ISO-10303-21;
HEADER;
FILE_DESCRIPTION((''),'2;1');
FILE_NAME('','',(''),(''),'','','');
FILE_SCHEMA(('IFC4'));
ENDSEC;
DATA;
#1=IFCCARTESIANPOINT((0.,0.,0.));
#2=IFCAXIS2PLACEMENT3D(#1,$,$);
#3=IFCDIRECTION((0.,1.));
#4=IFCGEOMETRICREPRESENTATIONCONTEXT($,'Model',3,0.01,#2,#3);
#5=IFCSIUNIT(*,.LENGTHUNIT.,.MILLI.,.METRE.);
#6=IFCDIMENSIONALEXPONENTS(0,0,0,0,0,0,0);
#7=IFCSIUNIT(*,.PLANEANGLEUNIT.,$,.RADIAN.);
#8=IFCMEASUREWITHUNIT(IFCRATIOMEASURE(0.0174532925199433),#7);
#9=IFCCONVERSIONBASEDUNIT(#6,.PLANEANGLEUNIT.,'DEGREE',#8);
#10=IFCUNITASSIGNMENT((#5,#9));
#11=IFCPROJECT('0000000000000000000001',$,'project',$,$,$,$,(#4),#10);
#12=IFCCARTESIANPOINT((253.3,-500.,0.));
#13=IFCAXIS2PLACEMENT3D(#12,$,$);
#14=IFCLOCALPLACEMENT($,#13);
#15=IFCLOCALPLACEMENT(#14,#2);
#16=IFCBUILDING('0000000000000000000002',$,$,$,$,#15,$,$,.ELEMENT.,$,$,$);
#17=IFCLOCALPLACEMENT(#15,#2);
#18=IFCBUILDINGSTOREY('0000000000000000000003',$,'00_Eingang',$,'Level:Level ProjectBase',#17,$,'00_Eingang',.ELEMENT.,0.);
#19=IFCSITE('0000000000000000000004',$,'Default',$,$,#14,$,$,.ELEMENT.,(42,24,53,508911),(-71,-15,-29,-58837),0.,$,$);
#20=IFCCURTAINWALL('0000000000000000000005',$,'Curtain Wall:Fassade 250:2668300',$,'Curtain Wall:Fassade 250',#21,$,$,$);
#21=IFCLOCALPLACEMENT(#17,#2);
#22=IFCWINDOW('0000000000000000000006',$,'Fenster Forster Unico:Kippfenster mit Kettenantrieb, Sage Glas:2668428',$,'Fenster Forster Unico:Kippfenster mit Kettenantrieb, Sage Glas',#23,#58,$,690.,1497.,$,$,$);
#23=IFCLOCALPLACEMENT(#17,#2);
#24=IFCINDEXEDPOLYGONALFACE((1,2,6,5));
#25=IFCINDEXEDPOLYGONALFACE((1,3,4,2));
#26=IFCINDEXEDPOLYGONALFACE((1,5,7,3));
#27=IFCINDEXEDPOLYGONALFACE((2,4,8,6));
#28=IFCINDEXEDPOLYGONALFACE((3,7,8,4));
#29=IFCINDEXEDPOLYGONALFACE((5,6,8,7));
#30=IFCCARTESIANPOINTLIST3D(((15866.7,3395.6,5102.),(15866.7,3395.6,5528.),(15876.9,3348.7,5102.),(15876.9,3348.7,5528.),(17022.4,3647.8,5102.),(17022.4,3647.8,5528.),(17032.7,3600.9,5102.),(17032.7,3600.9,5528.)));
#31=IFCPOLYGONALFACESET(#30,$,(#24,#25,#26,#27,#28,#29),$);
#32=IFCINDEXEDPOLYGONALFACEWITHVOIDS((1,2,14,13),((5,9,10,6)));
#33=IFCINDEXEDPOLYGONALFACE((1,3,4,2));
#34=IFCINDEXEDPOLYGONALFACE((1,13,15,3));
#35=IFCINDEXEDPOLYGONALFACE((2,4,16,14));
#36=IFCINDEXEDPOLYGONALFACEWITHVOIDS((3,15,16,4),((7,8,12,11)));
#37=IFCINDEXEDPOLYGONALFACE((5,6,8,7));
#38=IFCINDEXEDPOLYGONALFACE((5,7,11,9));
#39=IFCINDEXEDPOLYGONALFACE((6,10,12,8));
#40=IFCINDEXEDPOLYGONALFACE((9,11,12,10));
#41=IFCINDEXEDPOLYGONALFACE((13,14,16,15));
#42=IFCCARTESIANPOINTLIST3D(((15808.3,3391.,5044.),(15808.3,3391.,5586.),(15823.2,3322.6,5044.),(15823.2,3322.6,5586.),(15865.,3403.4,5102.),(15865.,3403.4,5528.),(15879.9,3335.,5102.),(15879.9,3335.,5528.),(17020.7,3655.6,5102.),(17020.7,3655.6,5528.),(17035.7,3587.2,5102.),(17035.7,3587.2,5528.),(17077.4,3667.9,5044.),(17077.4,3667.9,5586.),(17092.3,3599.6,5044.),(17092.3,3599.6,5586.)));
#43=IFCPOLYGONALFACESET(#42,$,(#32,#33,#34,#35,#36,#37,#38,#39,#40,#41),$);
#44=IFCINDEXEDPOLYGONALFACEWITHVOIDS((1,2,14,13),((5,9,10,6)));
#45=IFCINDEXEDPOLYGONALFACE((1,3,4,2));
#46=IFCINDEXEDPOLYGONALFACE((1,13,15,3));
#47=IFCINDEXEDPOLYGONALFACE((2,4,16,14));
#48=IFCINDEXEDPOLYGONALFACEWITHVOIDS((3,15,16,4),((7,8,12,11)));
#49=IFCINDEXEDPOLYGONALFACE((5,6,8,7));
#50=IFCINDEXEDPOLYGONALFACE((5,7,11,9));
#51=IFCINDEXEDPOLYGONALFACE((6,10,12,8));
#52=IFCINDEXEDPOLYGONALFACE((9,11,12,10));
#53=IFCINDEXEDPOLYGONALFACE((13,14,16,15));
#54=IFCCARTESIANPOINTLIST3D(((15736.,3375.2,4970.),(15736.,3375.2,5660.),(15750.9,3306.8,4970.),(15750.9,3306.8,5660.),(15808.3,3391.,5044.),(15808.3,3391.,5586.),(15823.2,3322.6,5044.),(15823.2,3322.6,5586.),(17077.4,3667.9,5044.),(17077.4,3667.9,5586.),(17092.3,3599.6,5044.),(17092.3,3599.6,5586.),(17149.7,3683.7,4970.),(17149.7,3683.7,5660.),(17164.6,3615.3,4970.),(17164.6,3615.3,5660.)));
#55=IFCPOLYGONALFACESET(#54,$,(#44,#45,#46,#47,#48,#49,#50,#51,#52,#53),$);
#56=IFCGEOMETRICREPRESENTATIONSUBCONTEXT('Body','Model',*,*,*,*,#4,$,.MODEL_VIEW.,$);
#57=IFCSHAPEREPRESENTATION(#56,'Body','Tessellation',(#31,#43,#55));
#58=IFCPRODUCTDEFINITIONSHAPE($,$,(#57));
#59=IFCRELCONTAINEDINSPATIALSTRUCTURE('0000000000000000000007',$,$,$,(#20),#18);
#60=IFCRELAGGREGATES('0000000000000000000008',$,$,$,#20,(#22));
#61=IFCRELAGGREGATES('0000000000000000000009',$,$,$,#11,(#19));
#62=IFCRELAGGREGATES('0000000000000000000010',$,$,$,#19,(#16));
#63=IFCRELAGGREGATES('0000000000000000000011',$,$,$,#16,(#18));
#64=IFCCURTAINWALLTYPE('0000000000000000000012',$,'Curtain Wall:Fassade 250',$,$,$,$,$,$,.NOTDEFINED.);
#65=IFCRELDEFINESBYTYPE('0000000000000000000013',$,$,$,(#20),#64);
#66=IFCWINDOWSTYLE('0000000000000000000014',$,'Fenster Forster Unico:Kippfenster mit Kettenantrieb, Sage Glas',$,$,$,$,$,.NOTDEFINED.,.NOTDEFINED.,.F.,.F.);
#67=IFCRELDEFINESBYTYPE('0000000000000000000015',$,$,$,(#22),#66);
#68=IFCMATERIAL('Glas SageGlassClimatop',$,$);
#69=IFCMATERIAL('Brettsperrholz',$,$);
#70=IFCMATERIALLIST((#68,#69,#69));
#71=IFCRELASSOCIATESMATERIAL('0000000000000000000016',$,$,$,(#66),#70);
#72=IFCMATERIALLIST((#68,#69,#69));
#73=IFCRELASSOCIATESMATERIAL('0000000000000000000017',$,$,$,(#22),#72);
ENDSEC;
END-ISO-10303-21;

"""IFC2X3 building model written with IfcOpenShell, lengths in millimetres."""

from ifc_helpers import new_model, entity, si_unit, converted_unit, direction, frame, origin, origin_2d_with_axis, place, context, subcontext, project, spatial, polyline, rectangle, outline, extrude, source, transform, mapped, material, material_list, type_object, type_shapes, element, aggregate, save


model = new_model("IFC2X3")

# Units and contexts
model_context = context("Model", 3, precision=0.01, world=origin(), true_north=direction((0.0, 1.0)))
body_context = subcontext(model_context, "Body", "Model", "MODEL_VIEW")
ifc_project = project(units=[si_unit("LENGTHUNIT", "METRE", prefix="MILLI"), converted_unit("PLANEANGLEUNIT", "DEGREE", entity("IfcRatioMeasure", 0.0174532925199433), si_unit("PLANEANGLEUNIT", "RADIAN"), dimensions=[0, 0, 0, 0, 0, 0, 0])], contexts=[model_context])

# Site, building, storey
site_placement = place(None, frame((253.3, -500.0, 0.0)))
site = spatial("IfcSite", under=ifc_project, at=site_placement, Name="Default", CompositionType="ELEMENT", RefLatitude=(42, 24, 53, 508911), RefLongitude=(-71, -15, -29, -58837), RefElevation=0.0)
building_placement = place(site_placement, origin())
building = spatial("IfcBuilding", under=site, at=building_placement, CompositionType="ELEMENT")
storey_placement = place(building_placement, origin())
storey = spatial("IfcBuildingStorey", under=building, at=storey_placement, Name="00_Eingang", ObjectType="Level:Level ProjectBase", LongName="00_Eingang", CompositionType="ELEMENT", Elevation=0.0)

# Curtain wall, window
curtain_wall_type = type_object("IfcCurtainWallType", Name="Curtain Wall:Fassade 250", PredefinedType="NOTDEFINED")
curtain_wall_placement = place(storey_placement, origin())
curtain_wall = element("IfcCurtainWall", 1, at=curtain_wall_placement, inside=storey, type_object=curtain_wall_type, Name="Curtain Wall:Fassade 250:2668300", ObjectType="Curtain Wall:Fassade 250")
ifc_material_1 = material(Name="Glas SageGlassClimatop")
ifc_material_2 = material(Name="Brettsperrholz")
ifc_material_list_1 = material_list([ifc_material_1, ifc_material_2, ifc_material_2])
ifc_material_list_2 = material_list([ifc_material_1, ifc_material_2, ifc_material_2])
window_style = type_object("IfcWindowStyle", Name="Fenster Forster Unico:Kippfenster mit Kettenantrieb, Sage Glas", ConstructionType="NOTDEFINED", OperationType="NOTDEFINED", ParameterTakesPrecedence=False, Sizeable=False, material=ifc_material_list_2)
shared_shape_1 = source(origin(), body_context, "Body", "SweptSolid", [
    extrude(rectangle(XDim=48.0, YDim=1183.0, at=origin_2d_with_axis()), frame((0.0, 12.0, 157.0), z_axis=(0.0, 0.0, 1.0), x_axis=(0.0, 1.0, 0.0)), (0.0, 0.0, 1.0), 426.0),
    extrude(outline(polyline([(-649.5, -271.0), (649.5, -271.0), (649.5, 271.0), (-649.5, 271.0), (-649.5, -271.0)]), holes=[polyline([(-591.5, 213.0), (591.5, 213.0), (591.5, -213.0), (-591.5, -213.0), (-591.5, 213.0)])]), frame((0.0, -26.0, 370.0), z_axis=(0.0, 1.0, 0.0), x_axis=(1.0, 0.0, 0.0)), (0.0, 0.0, 1.0), 70.0),
    extrude(outline(polyline([(-723.5, -345.0), (723.5, -345.0), (723.5, 345.0), (-723.5, 345.0), (-723.5, -345.0)]), holes=[polyline([(-649.5, 271.0), (649.5, 271.0), (649.5, -271.0), (-649.5, -271.0), (-649.5, 271.0)])]), frame((0.0, -26.0, 370.0), z_axis=(0.0, 1.0, 0.0), x_axis=(1.0, 0.0, 0.0)), (0.0, 0.0, 1.0), 70.0),
])
type_shapes(window_style, [shared_shape_1])
window_placement = place(curtain_wall_placement, frame((16452.2, 3486.5, 4945.0), z_axis=(0.0, 0.0, 1.0), x_axis=(0.977008, 0.213201, 0.0)))
window = element("IfcWindow", 2, at=window_placement, type_object=window_style, material=ifc_material_list_1, Name="Fenster Forster Unico:Kippfenster mit Kettenantrieb, Sage Glas:2668428", ObjectType="Fenster Forster Unico:Kippfenster mit Kettenantrieb, Sage Glas", OverallHeight=690.0, OverallWidth=1497.0, context=body_context, shape_type="MappedRepresentation", body=[
    mapped(shared_shape_1, transform((0.0, 0.0, 0.0), scale=1.0)),
])
aggregate(curtain_wall, [window])

save(model, "model.ifc")
